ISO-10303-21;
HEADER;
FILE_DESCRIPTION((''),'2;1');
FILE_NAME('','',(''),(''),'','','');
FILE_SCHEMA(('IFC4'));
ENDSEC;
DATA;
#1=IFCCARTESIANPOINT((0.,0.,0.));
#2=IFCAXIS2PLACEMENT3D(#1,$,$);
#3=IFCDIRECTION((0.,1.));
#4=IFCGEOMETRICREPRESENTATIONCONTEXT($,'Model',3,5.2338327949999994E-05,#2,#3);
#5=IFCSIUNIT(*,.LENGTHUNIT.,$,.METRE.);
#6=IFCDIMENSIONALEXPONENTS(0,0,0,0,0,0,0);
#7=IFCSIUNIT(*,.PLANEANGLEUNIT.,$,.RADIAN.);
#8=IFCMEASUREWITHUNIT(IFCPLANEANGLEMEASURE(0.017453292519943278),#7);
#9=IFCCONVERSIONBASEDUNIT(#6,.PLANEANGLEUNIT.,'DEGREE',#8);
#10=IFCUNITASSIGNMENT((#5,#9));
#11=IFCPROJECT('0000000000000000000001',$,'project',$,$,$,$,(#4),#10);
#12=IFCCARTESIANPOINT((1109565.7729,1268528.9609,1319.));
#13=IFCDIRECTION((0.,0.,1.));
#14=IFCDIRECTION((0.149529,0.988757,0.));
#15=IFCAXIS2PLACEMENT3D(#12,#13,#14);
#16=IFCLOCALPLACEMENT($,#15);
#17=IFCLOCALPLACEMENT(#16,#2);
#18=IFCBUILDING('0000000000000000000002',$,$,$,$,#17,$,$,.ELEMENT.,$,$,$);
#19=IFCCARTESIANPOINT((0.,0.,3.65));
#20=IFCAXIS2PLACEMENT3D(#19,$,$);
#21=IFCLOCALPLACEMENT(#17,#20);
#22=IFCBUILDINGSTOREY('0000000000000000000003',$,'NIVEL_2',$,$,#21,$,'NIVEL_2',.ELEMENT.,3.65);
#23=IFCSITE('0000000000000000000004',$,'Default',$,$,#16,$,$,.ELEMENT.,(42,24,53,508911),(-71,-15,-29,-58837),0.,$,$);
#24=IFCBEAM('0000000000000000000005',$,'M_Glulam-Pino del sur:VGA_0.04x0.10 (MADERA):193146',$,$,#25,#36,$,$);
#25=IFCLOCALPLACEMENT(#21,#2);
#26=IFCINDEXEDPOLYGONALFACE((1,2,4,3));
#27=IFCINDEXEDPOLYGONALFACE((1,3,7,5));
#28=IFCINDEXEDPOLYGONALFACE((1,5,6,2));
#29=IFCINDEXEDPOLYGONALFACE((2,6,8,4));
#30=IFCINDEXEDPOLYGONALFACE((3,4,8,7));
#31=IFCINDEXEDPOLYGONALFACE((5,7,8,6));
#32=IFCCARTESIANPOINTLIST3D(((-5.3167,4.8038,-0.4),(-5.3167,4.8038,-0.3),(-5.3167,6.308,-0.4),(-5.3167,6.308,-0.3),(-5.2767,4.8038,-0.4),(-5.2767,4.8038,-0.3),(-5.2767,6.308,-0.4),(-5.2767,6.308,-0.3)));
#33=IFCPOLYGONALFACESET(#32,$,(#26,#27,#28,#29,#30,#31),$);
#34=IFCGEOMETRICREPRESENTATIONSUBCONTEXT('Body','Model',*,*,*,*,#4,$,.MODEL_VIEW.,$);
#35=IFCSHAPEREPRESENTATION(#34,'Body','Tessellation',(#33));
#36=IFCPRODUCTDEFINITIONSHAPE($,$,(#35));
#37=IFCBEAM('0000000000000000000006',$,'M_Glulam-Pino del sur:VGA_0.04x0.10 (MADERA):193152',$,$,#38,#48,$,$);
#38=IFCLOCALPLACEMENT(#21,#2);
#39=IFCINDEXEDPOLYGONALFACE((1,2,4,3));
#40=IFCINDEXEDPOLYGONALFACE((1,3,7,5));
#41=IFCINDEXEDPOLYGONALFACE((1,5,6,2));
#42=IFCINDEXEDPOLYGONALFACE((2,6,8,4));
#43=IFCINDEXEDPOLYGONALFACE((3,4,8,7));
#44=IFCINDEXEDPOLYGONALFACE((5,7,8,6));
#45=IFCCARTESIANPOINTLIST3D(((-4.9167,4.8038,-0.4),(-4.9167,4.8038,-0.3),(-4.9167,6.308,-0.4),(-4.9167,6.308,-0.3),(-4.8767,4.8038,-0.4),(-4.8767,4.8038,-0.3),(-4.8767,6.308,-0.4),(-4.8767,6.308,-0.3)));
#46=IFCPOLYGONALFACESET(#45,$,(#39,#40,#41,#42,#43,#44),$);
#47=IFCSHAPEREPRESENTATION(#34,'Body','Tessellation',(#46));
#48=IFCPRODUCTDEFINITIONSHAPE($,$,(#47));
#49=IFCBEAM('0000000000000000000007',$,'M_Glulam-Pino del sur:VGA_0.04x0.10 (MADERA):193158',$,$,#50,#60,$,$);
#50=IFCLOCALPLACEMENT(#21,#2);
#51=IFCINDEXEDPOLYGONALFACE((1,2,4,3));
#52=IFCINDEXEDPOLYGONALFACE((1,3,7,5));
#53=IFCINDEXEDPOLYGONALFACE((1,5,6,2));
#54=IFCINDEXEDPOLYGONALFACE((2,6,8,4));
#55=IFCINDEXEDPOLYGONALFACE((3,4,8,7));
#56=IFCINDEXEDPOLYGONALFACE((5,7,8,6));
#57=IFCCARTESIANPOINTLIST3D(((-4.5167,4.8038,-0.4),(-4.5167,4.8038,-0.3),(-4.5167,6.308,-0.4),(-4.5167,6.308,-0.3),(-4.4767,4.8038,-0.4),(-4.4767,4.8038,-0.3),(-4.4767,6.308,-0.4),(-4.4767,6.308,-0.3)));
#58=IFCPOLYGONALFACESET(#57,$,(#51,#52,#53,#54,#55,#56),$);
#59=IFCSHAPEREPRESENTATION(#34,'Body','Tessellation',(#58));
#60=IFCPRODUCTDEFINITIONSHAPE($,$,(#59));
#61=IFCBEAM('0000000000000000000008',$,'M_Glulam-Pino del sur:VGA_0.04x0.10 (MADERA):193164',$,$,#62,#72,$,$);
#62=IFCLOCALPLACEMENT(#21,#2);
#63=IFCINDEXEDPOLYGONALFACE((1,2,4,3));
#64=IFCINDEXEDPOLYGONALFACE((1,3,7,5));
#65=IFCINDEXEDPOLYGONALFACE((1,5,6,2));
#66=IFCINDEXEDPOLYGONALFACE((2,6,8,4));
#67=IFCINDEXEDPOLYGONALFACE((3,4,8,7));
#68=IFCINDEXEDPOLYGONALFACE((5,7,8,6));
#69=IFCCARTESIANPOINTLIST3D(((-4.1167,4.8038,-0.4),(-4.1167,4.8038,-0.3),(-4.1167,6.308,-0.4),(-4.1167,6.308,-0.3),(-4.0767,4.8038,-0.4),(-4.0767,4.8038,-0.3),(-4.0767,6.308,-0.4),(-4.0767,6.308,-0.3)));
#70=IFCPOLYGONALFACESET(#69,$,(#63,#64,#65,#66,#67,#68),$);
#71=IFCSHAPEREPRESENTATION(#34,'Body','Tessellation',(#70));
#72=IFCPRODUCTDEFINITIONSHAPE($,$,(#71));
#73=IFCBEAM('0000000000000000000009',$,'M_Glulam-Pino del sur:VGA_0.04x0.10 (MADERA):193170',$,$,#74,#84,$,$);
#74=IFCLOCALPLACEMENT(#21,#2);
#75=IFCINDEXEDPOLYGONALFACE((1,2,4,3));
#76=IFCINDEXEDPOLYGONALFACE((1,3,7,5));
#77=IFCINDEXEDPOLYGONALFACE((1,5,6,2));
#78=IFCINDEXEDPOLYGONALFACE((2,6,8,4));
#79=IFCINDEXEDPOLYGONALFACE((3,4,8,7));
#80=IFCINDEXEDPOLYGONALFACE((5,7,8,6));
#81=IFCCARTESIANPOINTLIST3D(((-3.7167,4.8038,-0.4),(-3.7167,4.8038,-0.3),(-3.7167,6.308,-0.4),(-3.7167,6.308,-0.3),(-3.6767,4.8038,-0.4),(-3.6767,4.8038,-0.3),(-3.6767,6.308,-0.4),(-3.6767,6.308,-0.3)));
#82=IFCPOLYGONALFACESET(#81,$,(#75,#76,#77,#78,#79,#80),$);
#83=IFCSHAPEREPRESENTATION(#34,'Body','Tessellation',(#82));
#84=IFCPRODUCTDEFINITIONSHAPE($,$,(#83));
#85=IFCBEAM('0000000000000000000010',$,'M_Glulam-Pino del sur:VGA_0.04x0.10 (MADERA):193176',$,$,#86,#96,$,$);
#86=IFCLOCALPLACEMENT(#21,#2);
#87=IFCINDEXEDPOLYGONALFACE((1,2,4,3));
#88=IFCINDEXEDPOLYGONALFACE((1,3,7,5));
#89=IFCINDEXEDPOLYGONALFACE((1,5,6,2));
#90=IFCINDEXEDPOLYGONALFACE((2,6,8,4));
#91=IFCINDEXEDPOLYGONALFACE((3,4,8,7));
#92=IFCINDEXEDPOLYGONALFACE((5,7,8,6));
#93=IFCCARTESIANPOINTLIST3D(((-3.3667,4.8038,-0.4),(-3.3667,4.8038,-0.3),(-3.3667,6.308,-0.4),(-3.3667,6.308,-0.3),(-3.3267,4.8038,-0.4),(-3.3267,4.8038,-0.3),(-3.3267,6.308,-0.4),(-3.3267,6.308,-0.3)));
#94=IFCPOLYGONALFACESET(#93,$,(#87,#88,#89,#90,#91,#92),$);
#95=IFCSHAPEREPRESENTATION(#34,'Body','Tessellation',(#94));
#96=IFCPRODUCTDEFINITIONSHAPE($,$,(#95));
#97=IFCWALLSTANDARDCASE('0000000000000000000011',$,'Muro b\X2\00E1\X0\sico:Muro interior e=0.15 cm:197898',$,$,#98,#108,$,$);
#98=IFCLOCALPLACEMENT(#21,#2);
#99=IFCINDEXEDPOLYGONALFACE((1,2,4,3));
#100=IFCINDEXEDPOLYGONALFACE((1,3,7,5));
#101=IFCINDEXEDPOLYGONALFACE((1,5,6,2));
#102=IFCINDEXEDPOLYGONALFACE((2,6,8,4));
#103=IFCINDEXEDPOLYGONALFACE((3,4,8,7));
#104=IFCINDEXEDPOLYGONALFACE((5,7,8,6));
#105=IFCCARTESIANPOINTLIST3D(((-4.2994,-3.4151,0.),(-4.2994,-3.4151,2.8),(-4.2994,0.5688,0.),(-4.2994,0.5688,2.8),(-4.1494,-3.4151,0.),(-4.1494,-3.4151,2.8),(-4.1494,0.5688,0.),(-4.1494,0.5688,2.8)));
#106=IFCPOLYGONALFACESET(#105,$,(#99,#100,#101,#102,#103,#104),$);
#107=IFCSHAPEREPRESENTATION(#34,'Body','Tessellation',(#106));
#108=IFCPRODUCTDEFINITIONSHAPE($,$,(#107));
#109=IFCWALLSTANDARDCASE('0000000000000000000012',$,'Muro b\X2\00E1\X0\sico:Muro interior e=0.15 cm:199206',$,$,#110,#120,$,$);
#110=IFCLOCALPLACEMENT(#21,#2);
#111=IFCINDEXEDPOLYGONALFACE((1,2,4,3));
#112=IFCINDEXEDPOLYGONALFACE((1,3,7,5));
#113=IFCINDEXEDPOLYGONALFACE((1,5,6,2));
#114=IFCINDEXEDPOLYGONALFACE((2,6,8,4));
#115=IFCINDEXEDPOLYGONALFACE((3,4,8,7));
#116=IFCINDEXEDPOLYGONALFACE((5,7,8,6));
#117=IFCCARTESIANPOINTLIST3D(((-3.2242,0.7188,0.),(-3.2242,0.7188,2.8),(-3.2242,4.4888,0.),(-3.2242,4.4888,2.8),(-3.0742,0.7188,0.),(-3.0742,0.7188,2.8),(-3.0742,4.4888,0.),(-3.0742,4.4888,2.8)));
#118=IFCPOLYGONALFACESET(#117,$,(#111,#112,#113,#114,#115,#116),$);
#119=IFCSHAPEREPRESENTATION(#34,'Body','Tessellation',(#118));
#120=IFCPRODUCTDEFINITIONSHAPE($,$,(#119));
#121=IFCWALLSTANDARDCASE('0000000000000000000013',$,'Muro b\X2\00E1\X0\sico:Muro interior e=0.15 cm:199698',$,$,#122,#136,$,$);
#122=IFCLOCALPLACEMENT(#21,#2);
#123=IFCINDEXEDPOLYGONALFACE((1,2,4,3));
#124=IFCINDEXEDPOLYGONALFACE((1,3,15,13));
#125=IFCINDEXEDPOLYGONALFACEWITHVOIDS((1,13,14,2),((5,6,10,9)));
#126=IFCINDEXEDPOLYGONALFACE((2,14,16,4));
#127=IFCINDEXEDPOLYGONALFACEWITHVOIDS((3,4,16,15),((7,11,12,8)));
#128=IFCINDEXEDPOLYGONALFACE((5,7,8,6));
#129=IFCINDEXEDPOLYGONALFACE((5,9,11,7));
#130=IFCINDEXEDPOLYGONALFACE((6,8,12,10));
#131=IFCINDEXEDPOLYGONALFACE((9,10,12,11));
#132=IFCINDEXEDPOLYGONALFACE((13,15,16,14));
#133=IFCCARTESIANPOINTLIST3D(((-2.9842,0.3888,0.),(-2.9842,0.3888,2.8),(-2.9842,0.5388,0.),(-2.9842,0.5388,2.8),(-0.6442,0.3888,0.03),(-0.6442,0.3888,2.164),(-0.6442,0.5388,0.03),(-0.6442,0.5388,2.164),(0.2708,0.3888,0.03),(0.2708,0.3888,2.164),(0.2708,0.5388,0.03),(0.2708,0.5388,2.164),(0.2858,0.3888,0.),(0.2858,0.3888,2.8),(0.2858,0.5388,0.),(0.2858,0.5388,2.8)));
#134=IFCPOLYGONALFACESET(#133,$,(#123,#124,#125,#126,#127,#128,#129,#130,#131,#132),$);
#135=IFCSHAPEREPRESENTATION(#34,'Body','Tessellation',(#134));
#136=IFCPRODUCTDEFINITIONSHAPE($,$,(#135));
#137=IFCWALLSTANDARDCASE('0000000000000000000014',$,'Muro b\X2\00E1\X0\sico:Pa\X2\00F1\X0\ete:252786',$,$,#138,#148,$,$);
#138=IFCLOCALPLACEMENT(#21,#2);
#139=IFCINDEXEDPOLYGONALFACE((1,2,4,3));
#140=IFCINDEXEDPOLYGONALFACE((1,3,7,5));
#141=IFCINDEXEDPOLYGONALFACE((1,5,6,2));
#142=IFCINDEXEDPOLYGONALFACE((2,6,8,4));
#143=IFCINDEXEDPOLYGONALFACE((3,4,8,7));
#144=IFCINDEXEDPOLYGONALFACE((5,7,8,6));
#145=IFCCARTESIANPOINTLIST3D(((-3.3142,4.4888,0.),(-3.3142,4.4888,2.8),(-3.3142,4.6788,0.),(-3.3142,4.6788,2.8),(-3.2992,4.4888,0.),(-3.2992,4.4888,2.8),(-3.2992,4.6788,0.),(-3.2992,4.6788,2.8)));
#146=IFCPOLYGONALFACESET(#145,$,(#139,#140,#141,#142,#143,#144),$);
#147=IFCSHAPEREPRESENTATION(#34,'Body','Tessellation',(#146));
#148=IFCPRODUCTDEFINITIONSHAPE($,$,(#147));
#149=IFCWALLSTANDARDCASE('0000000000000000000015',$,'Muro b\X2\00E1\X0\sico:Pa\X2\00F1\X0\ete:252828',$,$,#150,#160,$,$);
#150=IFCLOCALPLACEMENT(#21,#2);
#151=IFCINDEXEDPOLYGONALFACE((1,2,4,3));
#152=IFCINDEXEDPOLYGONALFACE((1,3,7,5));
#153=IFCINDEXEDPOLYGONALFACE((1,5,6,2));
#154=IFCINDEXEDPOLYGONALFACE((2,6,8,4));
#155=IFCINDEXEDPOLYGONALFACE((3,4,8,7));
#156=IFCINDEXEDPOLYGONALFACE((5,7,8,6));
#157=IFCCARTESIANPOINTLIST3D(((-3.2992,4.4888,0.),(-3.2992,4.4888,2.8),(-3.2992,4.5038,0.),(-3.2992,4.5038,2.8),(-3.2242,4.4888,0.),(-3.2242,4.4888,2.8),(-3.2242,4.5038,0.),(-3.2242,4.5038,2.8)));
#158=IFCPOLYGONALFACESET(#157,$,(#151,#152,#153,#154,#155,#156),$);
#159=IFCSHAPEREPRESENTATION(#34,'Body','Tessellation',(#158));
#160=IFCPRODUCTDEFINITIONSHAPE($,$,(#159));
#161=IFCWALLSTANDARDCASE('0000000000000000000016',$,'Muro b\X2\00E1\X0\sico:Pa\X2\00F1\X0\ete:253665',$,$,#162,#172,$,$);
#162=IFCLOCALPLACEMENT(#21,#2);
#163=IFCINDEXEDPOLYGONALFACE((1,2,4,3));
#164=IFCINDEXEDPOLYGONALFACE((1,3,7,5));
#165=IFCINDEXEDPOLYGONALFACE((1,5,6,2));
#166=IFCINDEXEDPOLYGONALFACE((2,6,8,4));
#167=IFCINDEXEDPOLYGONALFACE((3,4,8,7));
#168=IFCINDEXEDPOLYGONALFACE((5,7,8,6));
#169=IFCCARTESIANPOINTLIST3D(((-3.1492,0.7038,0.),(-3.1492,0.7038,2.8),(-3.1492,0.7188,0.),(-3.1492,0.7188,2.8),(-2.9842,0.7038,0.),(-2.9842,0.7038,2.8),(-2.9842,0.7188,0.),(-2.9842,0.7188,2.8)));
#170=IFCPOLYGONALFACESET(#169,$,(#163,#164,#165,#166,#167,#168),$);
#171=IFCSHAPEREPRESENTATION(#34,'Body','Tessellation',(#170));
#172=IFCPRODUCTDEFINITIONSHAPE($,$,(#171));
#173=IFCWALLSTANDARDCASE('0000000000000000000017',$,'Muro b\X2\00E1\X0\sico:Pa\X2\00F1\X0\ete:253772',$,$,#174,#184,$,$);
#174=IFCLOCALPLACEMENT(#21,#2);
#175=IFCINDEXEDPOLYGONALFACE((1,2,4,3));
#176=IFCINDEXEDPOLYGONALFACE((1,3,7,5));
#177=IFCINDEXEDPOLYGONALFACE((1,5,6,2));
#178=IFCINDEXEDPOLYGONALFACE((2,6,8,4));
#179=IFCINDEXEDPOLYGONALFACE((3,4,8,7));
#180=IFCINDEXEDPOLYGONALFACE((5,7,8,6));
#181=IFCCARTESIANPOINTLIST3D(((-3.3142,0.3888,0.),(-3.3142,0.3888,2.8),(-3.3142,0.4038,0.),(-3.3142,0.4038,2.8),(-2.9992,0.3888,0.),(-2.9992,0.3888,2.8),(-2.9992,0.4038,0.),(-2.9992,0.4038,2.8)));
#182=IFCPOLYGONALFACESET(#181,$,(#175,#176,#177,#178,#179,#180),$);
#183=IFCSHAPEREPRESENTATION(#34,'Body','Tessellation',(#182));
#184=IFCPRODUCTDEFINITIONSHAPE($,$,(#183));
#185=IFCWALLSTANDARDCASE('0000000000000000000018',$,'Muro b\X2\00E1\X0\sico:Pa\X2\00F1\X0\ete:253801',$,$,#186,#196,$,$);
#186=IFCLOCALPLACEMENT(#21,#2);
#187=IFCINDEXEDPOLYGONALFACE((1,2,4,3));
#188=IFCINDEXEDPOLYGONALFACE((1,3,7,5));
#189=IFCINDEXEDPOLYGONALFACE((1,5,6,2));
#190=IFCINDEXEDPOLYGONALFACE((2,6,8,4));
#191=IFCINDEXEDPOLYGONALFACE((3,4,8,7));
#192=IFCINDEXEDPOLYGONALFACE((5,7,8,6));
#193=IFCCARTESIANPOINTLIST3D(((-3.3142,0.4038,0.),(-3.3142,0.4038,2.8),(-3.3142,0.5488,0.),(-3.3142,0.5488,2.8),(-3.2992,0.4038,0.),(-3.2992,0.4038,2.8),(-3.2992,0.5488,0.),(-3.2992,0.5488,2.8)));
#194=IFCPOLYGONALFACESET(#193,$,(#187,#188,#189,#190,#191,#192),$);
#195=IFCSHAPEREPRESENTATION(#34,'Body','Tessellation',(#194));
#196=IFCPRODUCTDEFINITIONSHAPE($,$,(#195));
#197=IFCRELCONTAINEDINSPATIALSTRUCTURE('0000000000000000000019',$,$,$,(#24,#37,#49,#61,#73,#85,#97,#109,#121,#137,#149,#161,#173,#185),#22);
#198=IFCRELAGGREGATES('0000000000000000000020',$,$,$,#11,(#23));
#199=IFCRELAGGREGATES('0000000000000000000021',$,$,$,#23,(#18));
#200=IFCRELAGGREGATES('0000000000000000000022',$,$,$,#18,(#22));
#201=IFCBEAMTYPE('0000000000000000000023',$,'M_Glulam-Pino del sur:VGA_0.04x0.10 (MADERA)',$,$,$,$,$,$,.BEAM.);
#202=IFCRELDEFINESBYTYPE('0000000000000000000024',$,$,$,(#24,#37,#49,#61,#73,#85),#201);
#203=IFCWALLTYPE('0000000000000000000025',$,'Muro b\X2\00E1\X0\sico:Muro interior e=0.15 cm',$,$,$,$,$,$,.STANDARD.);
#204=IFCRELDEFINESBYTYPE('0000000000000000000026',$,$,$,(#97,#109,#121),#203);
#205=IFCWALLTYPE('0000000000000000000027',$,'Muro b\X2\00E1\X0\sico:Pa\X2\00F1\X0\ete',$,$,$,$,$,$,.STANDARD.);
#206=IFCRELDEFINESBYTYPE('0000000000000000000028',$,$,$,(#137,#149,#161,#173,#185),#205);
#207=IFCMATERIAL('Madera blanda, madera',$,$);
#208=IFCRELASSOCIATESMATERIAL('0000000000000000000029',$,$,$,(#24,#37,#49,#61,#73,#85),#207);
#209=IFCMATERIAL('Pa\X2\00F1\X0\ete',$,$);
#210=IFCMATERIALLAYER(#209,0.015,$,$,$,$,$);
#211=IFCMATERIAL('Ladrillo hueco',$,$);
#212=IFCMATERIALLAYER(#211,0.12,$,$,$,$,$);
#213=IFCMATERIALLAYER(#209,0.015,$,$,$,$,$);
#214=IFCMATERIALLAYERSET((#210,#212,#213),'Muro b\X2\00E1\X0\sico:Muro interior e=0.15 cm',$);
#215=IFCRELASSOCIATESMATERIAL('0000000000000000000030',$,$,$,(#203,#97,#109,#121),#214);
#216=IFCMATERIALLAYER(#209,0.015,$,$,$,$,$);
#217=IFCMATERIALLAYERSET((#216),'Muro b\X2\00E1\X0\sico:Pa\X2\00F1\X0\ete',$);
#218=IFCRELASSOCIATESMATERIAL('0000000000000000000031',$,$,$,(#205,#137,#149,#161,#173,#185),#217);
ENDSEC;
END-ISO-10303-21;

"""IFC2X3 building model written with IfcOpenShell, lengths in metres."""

from ifc_helpers import new_model, entity, si_unit, converted_unit, direction, frame, frame_2d, origin, origin_2d_with_axis, place, context, subcontext, project, spatial, rectangle, extrude, material, layer, layer_set, layer_usage, type_object, element, save


model = new_model("IFC2X3")

# Units and contexts
model_context = context("Model", 3, precision=5.2338327949999994e-05, world=origin(), true_north=direction((0.0, 1.0)))
body_context = subcontext(model_context, "Body", "Model", "MODEL_VIEW")
ifc_project = project(units=[si_unit("LENGTHUNIT", "METRE"), converted_unit("PLANEANGLEUNIT", "DEGREE", entity("IfcPlaneAngleMeasure", 0.017453292519943278), si_unit("PLANEANGLEUNIT", "RADIAN"), dimensions=[0, 0, 0, 0, 0, 0, 0])], contexts=[model_context])

# Site, building, storey
site_placement = place(None, frame((1109565.7729, 1268528.9609, 1319.0), z_axis=(0.0, 0.0, 1.0), x_axis=(0.149529, 0.988757, 0.0)))
site = spatial("IfcSite", under=ifc_project, at=site_placement, Name="Default", CompositionType="ELEMENT", RefLatitude=(42, 24, 53, 508911), RefLongitude=(-71, -15, -29, -58837), RefElevation=0.0)
building_placement = place(site_placement, origin())
building = spatial("IfcBuilding", under=site, at=building_placement, CompositionType="ELEMENT")
storey_placement = place(building_placement, frame((0.0, 0.0, 3.65)))
storey = spatial("IfcBuildingStorey", under=building, at=storey_placement, Name="NIVEL_2", LongName="NIVEL_2", CompositionType="ELEMENT", Elevation=3.65)

# Beams
ifc_material_1 = material(Name="Madera blanda, madera")
beam_type = type_object("IfcBeamType", Name="M_Glulam-Pino del sur:VGA_0.04x0.10 (MADERA)", PredefinedType="BEAM")
beam_placement = place(storey_placement, frame((-5.2967, 4.8038, 0.0), z_axis=(0.0, 0.0, 1.0), x_axis=(0.0, 1.0, 0.0)))
element("IfcBeam", 1, at=beam_placement, inside=storey, type_object=beam_type, material=ifc_material_1, Name="M_Glulam-Pino del sur:VGA_0.04x0.10 (MADERA):193146", context=body_context, shape_type="SweptSolid", body=[
    extrude(rectangle(XDim=0.1, YDim=0.04, at=origin_2d_with_axis()), frame((0.0, 0.0, -0.35), z_axis=(1.0, 0.0, 0.0), x_axis=(0.0, 0.0, -1.0)), (0.0, 0.0, 1.0), 1.5042),
])
for number, where, z_axis, x_axis, name in (
    (2, (-4.8967, 4.8038, 0.0), (0.0, 0.0, 1.0), (0.0, 1.0, 0.0), "M_Glulam-Pino del sur:VGA_0.04x0.10 (MADERA):193152"),
    (3, (-4.4967, 4.8038, 0.0), (0.0, 0.0, 1.0), (0.0, 1.0, 0.0), "M_Glulam-Pino del sur:VGA_0.04x0.10 (MADERA):193158"),
    (4, (-4.0967, 4.8038, 0.0), (0.0, 0.0, 1.0), (0.0, 1.0, 0.0), "M_Glulam-Pino del sur:VGA_0.04x0.10 (MADERA):193164"),
    (5, (-3.6967, 4.8038, 0.0), (0.0, 0.0, 1.0), (0.0, 1.0, 0.0), "M_Glulam-Pino del sur:VGA_0.04x0.10 (MADERA):193170"),
    (6, (-3.3467, 4.8038, 0.0), (0.0, 0.0, 1.0), (0.0, 1.0, 0.0), "M_Glulam-Pino del sur:VGA_0.04x0.10 (MADERA):193176"),
):
    element("IfcBeam", number, at=place(storey_placement, frame(where, z_axis=z_axis, x_axis=x_axis)), inside=storey, type_object=beam_type, material=ifc_material_1, Name=name, context=body_context, shape_type="SweptSolid", body=[
        extrude(rectangle(XDim=0.1, YDim=0.04, at=frame_2d((0.0, 0.0), x_axis=(1.0, 0.0))), frame((0.0, 0.0, -0.35), z_axis=(1.0, 0.0, 0.0), x_axis=(0.0, 0.0, -1.0)), (0.0, 0.0, 1.0), 1.5042),
    ])

# Walls
ifc_material_2 = material(Name="Pañete")
ifc_layer_1 = layer(ifc_material_2, 0.015)
ifc_material_3 = material(Name="Ladrillo hueco")
ifc_layer_2 = layer(ifc_material_3, 0.12)
ifc_layer_3 = layer(ifc_material_2, 0.015)
ifc_layer_set_1 = layer_set([ifc_layer_1, ifc_layer_2, ifc_layer_3], Name="Muro básico:Muro interior e=0.15 cm")
ifc_layer_usage_1 = layer_usage(ifc_layer_set_1, "AXIS2", "NEGATIVE", 0.075)
wall_type_1 = type_object("IfcWallType", Name="Muro básico:Muro interior e=0.15 cm", PredefinedType="STANDARD", material=ifc_layer_set_1)
wall_1_placement = place(storey_placement, frame((-4.2244, 0.5688, 0.0), z_axis=(0.0, 0.0, 1.0), x_axis=(0.0, -1.0, 0.0)))
element("IfcWallStandardCase", 7, at=wall_1_placement, inside=storey, type_object=wall_type_1, material=ifc_layer_usage_1, Name="Muro básico:Muro interior e=0.15 cm:197898", context=body_context, shape_type="SweptSolid", body=[
    extrude(rectangle(XDim=3.9839, YDim=0.15, at=frame_2d((1.992, 0.0), x_axis=(-1.0, 0.0))), origin(), (0.0, 0.0, 1.0), 2.8),
])
ifc_layer_usage_2 = layer_usage(ifc_layer_set_1, "AXIS2", "NEGATIVE", 0.075)
wall_2_placement = place(storey_placement, frame((-3.1492, 4.4888, 0.0), z_axis=(0.0, 0.0, 1.0), x_axis=(0.0, -1.0, 0.0)))
element("IfcWallStandardCase", 8, at=wall_2_placement, inside=storey, type_object=wall_type_1, material=ifc_layer_usage_2, Name="Muro básico:Muro interior e=0.15 cm:199206", context=body_context, shape_type="SweptSolid", body=[
    extrude(rectangle(XDim=3.77, YDim=0.15, at=frame_2d((1.885, 0.0), x_axis=(-1.0, 0.0))), origin(), (0.0, 0.0, 1.0), 2.8),
])

# Wall, opening
ifc_layer_usage_3 = layer_usage(ifc_layer_set_1, "AXIS2", "POSITIVE", -0.075)
wall_3_placement = place(storey_placement, frame((-2.9842, 0.4638, 0.0)))
wall_3 = element("IfcWallStandardCase", 9, at=wall_3_placement, inside=storey, type_object=wall_type_1, material=ifc_layer_usage_3, Name="Muro básico:Muro interior e=0.15 cm:199698", context=body_context, shape_type="SweptSolid", body=[
    extrude(rectangle(XDim=3.27, YDim=0.15, at=frame_2d((1.635, 0.0), x_axis=(-1.0, 0.0))), origin(), (0.0, 0.0, 1.0), 2.8),
])
opening_1_placement = place(wall_3_placement, frame((2.9842, -0.4638, 0.0)))
element("IfcOpeningElement", 10, at=opening_1_placement, cuts=wall_3, ObjectType="Opening", context=body_context, shape_type="SweptSolid", body=[
    extrude(rectangle(XDim=2.134, YDim=0.915, at=origin_2d_with_axis()), frame((-0.1867, -0.9852, 1.097), z_axis=(0.0, 1.0, 0.0), x_axis=(0.0, 0.0, -1.0)), (0.0, 0.0, 1.0), 3.048),
])

# Walls
ifc_layer_4 = layer(ifc_material_2, 0.015)
ifc_layer_set_2 = layer_set([ifc_layer_4], Name="Muro básico:Pañete")
ifc_layer_usage_4 = layer_usage(ifc_layer_set_2, "AXIS2", "POSITIVE", -0.0075)
wall_type_2 = type_object("IfcWallType", Name="Muro básico:Pañete", PredefinedType="STANDARD", material=ifc_layer_set_2)
wall_4_placement = place(storey_placement, frame((-3.3067, 4.6788, 0.0), z_axis=(0.0, 0.0, 1.0), x_axis=(0.0, -1.0, 0.0)))
element("IfcWallStandardCase", 11, at=wall_4_placement, inside=storey, type_object=wall_type_2, material=ifc_layer_usage_4, Name="Muro básico:Pañete:252786", context=body_context, shape_type="SweptSolid", body=[
    extrude(rectangle(XDim=0.19, YDim=0.015, at=frame_2d((0.095, 0.0), x_axis=(-1.0, 0.0))), origin(), (0.0, 0.0, 1.0), 2.8),
])
ifc_layer_usage_5 = layer_usage(ifc_layer_set_2, "AXIS2", "POSITIVE", -0.0075)
wall_5_placement = place(storey_placement, frame((-3.2992, 4.4963, 0.0)))
element("IfcWallStandardCase", 12, at=wall_5_placement, inside=storey, type_object=wall_type_2, material=ifc_layer_usage_5, Name="Muro básico:Pañete:252828", context=body_context, shape_type="SweptSolid", body=[
    extrude(rectangle(XDim=0.075, YDim=0.015, at=frame_2d((0.0375, 0.0), x_axis=(-1.0, 0.0))), origin(), (0.0, 0.0, 1.0), 2.8),
])
ifc_layer_usage_6 = layer_usage(ifc_layer_set_2, "AXIS2", "NEGATIVE", 0.0075)
wall_6_placement = place(storey_placement, frame((-3.1492, 0.7113, 0.0)))
element("IfcWallStandardCase", 13, at=wall_6_placement, inside=storey, type_object=wall_type_2, material=ifc_layer_usage_6, Name="Muro básico:Pañete:253665", context=body_context, shape_type="SweptSolid", body=[
    extrude(rectangle(XDim=0.165, YDim=0.015, at=frame_2d((0.0825, 0.0), x_axis=(-1.0, 0.0))), origin(), (0.0, 0.0, 1.0), 2.8),
])
ifc_layer_usage_7 = layer_usage(ifc_layer_set_2, "AXIS2", "NEGATIVE", 0.0075)
wall_7_placement = place(storey_placement, frame((-2.9992, 0.3963, 0.0), z_axis=(0.0, 0.0, 1.0), x_axis=(-1.0, 0.0, 0.0)))
element("IfcWallStandardCase", 14, at=wall_7_placement, inside=storey, type_object=wall_type_2, material=ifc_layer_usage_7, Name="Muro básico:Pañete:253772", context=body_context, shape_type="SweptSolid", body=[
    extrude(rectangle(XDim=0.315, YDim=0.015, at=frame_2d((0.1575, 0.0), x_axis=(-1.0, 0.0))), origin(), (0.0, 0.0, 1.0), 2.8),
])
ifc_layer_usage_8 = layer_usage(ifc_layer_set_2, "AXIS2", "NEGATIVE", 0.0075)
wall_8_placement = place(storey_placement, frame((-3.3067, 0.4038, 0.0), z_axis=(0.0, 0.0, 1.0), x_axis=(0.0, 1.0, 0.0)))
element("IfcWallStandardCase", 15, at=wall_8_placement, inside=storey, type_object=wall_type_2, material=ifc_layer_usage_8, Name="Muro básico:Pañete:253801", context=body_context, shape_type="SweptSolid", body=[
    extrude(rectangle(XDim=0.145, YDim=0.015, at=frame_2d((0.0725, 0.0), x_axis=(-1.0, 0.0))), origin(), (0.0, 0.0, 1.0), 2.8),
])

save(model, "model.ifc")
